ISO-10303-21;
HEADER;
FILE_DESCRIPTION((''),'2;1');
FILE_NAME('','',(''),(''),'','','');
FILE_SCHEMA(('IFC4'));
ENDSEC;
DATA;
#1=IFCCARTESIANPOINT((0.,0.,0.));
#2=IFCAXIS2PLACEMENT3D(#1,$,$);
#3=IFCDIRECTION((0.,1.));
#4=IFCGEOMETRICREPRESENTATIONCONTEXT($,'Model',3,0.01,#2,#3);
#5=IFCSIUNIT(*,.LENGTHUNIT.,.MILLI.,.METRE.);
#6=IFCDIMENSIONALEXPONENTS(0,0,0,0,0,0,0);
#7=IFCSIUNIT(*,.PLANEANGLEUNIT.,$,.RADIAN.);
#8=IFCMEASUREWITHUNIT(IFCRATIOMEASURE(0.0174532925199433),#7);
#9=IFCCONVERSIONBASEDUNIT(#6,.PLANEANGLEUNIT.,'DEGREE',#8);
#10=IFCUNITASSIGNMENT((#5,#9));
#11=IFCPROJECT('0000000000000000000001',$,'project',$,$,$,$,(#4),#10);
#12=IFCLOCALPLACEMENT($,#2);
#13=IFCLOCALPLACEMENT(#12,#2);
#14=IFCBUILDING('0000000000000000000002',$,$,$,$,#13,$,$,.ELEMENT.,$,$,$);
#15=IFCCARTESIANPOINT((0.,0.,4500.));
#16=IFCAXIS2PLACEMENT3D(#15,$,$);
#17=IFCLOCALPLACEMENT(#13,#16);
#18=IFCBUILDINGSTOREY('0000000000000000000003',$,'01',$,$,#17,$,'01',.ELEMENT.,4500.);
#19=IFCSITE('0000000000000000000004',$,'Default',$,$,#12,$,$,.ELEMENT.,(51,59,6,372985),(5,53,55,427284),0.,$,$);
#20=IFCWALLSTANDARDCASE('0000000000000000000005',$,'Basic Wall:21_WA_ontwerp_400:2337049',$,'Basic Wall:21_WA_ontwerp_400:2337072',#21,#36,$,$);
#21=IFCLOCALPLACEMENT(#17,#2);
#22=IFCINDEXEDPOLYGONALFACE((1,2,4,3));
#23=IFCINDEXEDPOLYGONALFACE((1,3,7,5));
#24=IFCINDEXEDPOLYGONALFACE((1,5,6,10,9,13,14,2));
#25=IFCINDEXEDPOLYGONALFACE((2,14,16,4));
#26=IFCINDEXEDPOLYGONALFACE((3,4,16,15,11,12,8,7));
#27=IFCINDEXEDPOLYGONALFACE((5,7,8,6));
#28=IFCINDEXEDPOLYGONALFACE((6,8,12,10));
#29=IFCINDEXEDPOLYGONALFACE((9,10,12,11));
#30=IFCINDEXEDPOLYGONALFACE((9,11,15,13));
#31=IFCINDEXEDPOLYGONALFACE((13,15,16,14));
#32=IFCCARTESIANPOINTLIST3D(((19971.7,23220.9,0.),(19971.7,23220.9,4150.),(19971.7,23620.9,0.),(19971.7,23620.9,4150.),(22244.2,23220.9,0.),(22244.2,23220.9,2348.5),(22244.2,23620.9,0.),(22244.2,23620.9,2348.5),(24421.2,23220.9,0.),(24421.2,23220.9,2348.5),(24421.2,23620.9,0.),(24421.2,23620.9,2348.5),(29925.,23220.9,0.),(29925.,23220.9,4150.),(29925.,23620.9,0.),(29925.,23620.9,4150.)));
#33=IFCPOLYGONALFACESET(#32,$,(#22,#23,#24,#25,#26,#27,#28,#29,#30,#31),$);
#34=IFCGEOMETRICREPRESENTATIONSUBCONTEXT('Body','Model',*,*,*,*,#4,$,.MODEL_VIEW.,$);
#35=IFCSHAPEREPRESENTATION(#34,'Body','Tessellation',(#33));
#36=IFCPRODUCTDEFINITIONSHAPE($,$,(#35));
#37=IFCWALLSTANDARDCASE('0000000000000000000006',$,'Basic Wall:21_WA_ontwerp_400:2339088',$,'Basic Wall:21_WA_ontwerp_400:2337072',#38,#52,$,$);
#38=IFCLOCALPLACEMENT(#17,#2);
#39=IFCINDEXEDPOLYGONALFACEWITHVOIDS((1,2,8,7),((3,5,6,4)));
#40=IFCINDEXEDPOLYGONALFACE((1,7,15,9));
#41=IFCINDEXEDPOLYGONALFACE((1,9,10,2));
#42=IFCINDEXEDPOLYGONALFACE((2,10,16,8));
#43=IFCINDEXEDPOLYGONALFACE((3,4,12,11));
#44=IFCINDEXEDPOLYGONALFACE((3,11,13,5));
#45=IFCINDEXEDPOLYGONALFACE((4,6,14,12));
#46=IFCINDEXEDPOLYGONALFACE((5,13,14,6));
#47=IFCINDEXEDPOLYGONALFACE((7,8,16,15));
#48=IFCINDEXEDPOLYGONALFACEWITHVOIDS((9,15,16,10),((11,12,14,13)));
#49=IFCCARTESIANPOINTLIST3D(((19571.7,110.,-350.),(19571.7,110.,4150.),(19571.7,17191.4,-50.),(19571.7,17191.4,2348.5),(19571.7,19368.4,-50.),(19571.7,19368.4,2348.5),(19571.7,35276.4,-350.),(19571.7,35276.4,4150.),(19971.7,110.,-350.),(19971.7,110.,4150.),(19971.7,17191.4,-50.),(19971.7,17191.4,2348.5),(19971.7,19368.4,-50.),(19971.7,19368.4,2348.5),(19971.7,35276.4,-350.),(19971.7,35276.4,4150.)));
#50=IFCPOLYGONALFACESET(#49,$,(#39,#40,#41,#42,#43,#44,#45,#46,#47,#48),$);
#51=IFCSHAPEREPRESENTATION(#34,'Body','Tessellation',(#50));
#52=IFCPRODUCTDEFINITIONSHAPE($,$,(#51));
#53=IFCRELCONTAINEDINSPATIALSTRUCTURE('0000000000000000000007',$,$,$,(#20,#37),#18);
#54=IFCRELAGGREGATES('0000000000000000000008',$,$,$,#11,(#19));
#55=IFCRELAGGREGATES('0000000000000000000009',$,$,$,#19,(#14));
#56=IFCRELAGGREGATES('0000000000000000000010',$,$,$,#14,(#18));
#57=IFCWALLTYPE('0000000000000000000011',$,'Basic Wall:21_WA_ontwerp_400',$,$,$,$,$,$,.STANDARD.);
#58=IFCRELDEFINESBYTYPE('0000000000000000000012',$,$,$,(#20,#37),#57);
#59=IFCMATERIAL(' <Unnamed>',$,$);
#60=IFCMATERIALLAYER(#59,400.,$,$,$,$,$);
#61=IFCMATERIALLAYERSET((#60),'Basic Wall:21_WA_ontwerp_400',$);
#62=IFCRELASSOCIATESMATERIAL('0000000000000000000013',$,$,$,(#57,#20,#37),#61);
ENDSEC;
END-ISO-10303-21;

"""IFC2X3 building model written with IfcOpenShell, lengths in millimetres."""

from ifc_helpers import new_model, entity, si_unit, converted_unit, direction, frame, frame_2d, origin, origin_2d_with_axis, place, context, subcontext, project, spatial, rectangle, extrude, material, layer, layer_set, layer_usage, type_object, element, save


model = new_model("IFC2X3")

# Units and contexts
model_context = context("Model", 3, precision=0.01, world=origin(), true_north=direction((0.0, 1.0)))
body_context = subcontext(model_context, "Body", "Model", "MODEL_VIEW")
ifc_project = project(units=[si_unit("LENGTHUNIT", "METRE", prefix="MILLI"), converted_unit("PLANEANGLEUNIT", "DEGREE", entity("IfcRatioMeasure", 0.0174532925199433), si_unit("PLANEANGLEUNIT", "RADIAN"), dimensions=[0, 0, 0, 0, 0, 0, 0])], contexts=[model_context])

# Site, building, storey
site_placement = place(None, origin())
site = spatial("IfcSite", under=ifc_project, at=site_placement, Name="Default", CompositionType="ELEMENT", RefLatitude=(51, 59, 6, 372985), RefLongitude=(5, 53, 55, 427284), RefElevation=0.0)
building_placement = place(site_placement, origin())
building = spatial("IfcBuilding", under=site, at=building_placement, CompositionType="ELEMENT")
storey_placement = place(building_placement, frame((0.0, 0.0, 4500.0)))
storey = spatial("IfcBuildingStorey", under=building, at=storey_placement, Name="01", LongName="01", CompositionType="ELEMENT", Elevation=4500.0)

# Walls, openings
ifc_material_1 = material(Name=" <Unnamed>")
ifc_layer = layer(ifc_material_1, 400.0)
ifc_layer_set = layer_set([ifc_layer], Name="Basic Wall:21_WA_ontwerp_400")
ifc_layer_usage_1 = layer_usage(ifc_layer_set, "AXIS2", "NEGATIVE", 200.0)
wall_type = type_object("IfcWallType", Name="Basic Wall:21_WA_ontwerp_400", PredefinedType="STANDARD", material=ifc_layer_set)
wall_1_placement = place(storey_placement, frame((19971.7, 23420.9, 0.0)))
wall_1 = element("IfcWallStandardCase", 1, at=wall_1_placement, inside=storey, type_object=wall_type, material=ifc_layer_usage_1, Name="Basic Wall:21_WA_ontwerp_400:2337049", ObjectType="Basic Wall:21_WA_ontwerp_400:2337072", context=body_context, shape_type="SweptSolid", body=[
    extrude(rectangle(XDim=9953.3, YDim=400.0, at=frame_2d((4976.7, 0.0), x_axis=(-1.0, 0.0))), origin(), (0.0, 0.0, 1.0), 4150.0),
])
opening_1_placement = place(wall_1_placement, frame((-19971.7, -23420.9, 0.0)))
element("IfcOpeningElement", 2, at=opening_1_placement, cuts=wall_1, ObjectType="Opening", context=body_context, shape_type="SweptSolid", body=[
    extrude(rectangle(XDim=2398.5, YDim=2177.0, at=frame_2d((0.0, 0.0), x_axis=(0.0, 1.0))), frame((23332.7, 23220.9, 1149.3), z_axis=(0.0, 1.0, 0.0), x_axis=(1.0, 0.0, 0.0)), (0.0, 0.0, 1.0), 400.0),
])
ifc_layer_usage_2 = layer_usage(ifc_layer_set, "AXIS2", "NEGATIVE", 200.0)
wall_2_placement = place(storey_placement, frame((19771.7, 35276.4, -350.0), z_axis=(0.0, 0.0, 1.0), x_axis=(0.0, -1.0, 0.0)))
wall_2 = element("IfcWallStandardCase", 3, at=wall_2_placement, inside=storey, type_object=wall_type, material=ifc_layer_usage_2, Name="Basic Wall:21_WA_ontwerp_400:2339088", ObjectType="Basic Wall:21_WA_ontwerp_400:2337072", context=body_context, shape_type="SweptSolid", body=[
    extrude(rectangle(XDim=35166.4, YDim=400.0, at=frame_2d((17583.2, 0.0), x_axis=(-1.0, 0.0))), origin(), (0.0, 0.0, 1.0), 4500.0),
])
opening_2_placement = place(wall_2_placement, frame((35276.4, -19771.7, 350.0), z_axis=(0.0, 0.0, 1.0), x_axis=(0.0, 1.0, 0.0)))
element("IfcOpeningElement", 4, at=opening_2_placement, cuts=wall_2, ObjectType="Opening", context=body_context, shape_type="SweptSolid", body=[
    extrude(rectangle(XDim=2398.5, YDim=2177.0, at=origin_2d_with_axis()), frame((19571.7, 18279.9, 1149.3), z_axis=(1.0, 0.0, 0.0), x_axis=(0.0, 0.0, -1.0)), (0.0, 0.0, 1.0), 400.0),
])

save(model, "model.ifc")
